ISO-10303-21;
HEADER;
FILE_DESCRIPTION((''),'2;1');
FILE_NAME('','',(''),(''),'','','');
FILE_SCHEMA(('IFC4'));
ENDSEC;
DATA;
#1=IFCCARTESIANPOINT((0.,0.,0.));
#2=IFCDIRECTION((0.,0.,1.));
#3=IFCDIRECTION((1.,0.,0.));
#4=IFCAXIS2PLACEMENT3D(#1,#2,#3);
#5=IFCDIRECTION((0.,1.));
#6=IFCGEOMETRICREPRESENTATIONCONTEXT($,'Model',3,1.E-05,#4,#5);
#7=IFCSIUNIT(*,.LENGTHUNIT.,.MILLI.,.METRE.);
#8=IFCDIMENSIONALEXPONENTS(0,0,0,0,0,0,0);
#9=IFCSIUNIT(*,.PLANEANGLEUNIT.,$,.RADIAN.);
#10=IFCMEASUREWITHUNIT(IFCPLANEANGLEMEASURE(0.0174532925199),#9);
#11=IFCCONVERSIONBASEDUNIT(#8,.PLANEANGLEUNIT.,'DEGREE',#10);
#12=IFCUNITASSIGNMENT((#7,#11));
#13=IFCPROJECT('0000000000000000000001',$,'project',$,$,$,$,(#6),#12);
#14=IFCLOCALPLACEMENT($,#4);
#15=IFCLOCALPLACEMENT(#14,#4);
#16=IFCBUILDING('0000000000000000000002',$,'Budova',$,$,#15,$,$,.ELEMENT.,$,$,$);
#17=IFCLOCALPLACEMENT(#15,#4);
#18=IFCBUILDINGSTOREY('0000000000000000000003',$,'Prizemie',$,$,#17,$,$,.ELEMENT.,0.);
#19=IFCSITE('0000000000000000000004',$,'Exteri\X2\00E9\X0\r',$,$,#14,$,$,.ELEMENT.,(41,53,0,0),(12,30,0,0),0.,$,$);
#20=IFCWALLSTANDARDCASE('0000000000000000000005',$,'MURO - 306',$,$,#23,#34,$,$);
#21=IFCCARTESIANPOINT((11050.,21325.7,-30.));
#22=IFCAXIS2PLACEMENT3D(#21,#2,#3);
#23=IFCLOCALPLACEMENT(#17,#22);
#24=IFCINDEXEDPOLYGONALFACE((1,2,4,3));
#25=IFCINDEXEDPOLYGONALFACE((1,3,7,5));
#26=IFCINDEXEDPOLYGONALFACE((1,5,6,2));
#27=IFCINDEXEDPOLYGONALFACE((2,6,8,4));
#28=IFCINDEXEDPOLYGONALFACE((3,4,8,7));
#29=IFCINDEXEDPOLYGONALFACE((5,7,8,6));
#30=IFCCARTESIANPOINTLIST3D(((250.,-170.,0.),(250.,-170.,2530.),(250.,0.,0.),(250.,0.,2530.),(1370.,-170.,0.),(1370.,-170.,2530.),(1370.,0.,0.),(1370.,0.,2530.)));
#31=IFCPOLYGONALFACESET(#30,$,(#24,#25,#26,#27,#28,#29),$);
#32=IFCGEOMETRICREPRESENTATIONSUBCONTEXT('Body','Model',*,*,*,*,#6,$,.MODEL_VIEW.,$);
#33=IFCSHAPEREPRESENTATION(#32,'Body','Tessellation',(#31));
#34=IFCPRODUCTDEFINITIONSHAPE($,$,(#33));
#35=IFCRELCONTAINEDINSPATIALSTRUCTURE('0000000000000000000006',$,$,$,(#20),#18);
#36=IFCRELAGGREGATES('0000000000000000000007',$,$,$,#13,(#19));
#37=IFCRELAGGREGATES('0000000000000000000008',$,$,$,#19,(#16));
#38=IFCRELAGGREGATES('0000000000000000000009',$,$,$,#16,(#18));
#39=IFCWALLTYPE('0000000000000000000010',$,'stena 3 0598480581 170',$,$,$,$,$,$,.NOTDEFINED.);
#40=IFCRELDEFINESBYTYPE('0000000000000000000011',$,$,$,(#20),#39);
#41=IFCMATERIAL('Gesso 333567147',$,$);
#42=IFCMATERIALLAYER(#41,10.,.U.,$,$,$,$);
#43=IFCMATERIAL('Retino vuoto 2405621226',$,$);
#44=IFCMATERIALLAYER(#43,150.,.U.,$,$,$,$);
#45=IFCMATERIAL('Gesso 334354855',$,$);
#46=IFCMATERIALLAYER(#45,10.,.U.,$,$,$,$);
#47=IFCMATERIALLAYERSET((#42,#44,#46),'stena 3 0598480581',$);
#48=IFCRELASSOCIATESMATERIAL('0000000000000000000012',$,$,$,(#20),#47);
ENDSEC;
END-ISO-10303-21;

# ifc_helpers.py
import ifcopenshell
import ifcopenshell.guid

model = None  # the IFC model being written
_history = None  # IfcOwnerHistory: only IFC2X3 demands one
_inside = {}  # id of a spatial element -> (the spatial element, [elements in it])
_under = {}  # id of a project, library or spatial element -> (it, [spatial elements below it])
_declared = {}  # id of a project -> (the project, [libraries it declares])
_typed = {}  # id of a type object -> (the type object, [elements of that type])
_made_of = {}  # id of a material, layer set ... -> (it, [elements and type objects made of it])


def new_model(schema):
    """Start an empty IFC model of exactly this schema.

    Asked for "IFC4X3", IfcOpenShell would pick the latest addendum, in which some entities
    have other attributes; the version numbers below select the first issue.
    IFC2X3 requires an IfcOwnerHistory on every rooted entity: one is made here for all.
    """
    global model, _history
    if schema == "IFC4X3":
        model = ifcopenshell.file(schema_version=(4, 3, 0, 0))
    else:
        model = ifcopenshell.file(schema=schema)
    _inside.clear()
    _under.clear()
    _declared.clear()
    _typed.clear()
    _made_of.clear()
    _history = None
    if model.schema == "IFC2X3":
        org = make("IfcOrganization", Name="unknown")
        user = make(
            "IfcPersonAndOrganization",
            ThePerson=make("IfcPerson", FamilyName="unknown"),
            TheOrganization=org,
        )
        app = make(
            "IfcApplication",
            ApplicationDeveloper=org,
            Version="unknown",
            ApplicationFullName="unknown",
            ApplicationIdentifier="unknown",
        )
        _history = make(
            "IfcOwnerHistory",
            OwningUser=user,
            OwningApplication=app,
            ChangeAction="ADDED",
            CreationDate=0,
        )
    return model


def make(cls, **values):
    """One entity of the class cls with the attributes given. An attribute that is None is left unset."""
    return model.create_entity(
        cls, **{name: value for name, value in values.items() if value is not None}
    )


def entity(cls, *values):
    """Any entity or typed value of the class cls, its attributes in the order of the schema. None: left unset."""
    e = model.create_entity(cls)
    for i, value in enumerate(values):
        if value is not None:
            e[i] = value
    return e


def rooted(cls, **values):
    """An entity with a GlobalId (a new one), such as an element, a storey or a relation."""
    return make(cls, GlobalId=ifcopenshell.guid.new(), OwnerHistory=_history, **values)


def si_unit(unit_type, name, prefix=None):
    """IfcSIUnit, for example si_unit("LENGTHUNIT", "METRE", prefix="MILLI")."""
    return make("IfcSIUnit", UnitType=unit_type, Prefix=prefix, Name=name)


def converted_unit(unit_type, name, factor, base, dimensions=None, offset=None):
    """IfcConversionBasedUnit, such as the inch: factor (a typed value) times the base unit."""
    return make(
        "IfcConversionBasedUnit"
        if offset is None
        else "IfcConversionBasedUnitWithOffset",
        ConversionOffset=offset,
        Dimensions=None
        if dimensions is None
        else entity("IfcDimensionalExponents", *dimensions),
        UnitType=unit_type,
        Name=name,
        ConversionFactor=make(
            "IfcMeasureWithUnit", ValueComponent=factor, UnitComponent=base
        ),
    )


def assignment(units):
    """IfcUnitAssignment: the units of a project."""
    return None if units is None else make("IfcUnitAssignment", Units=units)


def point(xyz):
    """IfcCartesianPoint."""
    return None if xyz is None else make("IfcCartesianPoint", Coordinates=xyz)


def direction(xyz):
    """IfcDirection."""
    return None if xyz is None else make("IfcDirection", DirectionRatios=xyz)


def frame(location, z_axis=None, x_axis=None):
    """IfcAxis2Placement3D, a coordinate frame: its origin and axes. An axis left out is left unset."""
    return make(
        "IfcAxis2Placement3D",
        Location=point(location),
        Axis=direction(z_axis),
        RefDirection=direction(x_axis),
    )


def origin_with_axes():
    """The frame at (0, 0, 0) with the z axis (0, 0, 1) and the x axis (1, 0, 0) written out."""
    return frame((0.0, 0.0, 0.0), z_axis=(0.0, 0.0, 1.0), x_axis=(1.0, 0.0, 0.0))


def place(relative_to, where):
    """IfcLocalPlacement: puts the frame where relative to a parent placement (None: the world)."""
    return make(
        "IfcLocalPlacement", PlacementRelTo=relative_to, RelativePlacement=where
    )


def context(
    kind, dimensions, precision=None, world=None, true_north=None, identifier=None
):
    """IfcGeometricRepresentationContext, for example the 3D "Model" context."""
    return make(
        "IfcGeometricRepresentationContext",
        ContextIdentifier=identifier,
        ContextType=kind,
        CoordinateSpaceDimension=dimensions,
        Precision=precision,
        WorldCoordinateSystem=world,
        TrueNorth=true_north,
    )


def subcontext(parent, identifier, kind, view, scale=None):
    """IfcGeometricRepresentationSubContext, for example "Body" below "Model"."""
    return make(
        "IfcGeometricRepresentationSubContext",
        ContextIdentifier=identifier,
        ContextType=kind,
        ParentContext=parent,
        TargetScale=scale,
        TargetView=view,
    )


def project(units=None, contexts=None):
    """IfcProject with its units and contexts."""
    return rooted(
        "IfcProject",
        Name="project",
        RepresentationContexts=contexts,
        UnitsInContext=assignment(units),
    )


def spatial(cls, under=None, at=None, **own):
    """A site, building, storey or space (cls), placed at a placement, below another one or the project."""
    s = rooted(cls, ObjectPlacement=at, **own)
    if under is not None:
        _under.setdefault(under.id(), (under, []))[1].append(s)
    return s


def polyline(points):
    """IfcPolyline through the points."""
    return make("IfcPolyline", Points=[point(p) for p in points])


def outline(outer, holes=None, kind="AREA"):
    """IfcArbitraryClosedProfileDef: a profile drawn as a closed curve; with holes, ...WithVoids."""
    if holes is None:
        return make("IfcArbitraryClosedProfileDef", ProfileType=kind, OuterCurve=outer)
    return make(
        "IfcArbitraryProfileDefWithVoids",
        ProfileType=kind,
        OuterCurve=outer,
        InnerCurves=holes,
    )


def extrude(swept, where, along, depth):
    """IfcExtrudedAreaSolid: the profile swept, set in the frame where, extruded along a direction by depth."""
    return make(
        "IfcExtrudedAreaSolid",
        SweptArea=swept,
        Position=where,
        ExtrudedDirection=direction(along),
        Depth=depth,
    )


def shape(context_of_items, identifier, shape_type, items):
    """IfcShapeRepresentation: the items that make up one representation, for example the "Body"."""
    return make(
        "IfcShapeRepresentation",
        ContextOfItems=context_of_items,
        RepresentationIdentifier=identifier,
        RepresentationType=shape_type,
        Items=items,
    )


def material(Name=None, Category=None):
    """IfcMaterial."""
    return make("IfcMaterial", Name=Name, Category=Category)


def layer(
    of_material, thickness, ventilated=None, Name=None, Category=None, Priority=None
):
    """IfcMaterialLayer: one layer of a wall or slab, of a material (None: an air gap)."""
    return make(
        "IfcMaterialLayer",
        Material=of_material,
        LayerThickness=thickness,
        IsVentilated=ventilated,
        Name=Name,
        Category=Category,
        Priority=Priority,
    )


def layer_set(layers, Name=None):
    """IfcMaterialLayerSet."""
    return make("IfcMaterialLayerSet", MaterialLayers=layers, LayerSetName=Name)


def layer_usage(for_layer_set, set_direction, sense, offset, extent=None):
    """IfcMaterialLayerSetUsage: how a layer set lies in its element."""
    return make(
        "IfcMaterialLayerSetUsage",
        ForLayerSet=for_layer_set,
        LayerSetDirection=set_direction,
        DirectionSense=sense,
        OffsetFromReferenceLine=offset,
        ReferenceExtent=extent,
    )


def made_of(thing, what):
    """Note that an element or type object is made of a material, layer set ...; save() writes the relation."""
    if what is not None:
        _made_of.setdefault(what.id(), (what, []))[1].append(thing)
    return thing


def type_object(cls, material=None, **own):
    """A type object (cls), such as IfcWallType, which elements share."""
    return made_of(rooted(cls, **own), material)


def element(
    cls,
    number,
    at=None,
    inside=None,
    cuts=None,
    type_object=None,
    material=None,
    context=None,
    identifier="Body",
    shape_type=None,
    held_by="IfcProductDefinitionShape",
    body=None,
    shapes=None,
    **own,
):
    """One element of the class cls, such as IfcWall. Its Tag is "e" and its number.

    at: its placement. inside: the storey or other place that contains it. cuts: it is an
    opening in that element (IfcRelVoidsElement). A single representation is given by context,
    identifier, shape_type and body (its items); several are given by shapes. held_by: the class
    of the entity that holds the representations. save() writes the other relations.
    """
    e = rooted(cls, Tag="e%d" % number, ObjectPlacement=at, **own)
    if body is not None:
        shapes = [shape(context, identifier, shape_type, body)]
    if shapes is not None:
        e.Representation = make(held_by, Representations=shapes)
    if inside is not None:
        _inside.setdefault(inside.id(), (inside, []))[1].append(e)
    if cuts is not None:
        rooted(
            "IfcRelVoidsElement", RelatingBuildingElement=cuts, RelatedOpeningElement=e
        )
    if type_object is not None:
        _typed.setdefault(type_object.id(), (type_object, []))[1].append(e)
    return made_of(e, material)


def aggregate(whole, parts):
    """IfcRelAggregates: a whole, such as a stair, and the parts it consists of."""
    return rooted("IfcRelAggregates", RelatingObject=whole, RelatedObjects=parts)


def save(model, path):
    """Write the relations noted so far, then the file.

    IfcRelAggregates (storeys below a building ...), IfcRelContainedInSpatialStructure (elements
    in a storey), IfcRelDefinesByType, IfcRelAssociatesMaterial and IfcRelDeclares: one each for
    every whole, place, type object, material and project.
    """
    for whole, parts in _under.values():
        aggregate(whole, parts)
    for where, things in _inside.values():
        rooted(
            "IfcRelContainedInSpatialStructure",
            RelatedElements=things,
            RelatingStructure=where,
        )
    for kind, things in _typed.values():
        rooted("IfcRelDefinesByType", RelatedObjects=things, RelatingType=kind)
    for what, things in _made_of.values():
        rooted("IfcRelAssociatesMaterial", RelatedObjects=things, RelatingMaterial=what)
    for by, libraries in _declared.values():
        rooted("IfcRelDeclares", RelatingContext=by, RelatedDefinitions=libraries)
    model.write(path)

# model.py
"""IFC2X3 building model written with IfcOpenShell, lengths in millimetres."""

from ifc_helpers import new_model, entity, si_unit, converted_unit, direction, frame, origin_with_axes, place, context, subcontext, project, spatial, polyline, outline, extrude, material, layer, layer_set, layer_usage, type_object, element, save


model = new_model("IFC2X3")

# Units and contexts
model_context = context("Model", 3, precision=1e-05, world=origin_with_axes(), true_north=direction((0.0, 1.0)))
body_context = subcontext(model_context, "Body", "Model", "MODEL_VIEW")
ifc_project = project(units=[si_unit("LENGTHUNIT", "METRE", prefix="MILLI"), converted_unit("PLANEANGLEUNIT", "DEGREE", entity("IfcPlaneAngleMeasure", 0.0174532925199), si_unit("PLANEANGLEUNIT", "RADIAN"), dimensions=[0, 0, 0, 0, 0, 0, 0])], contexts=[model_context])

# Site, building, storey
site_placement = place(None, origin_with_axes())
site = spatial("IfcSite", under=ifc_project, at=site_placement, Name="Exteriér", CompositionType="ELEMENT", RefLatitude=(41, 53, 0, 0), RefLongitude=(12, 30, 0, 0), RefElevation=0.0)
building_placement = place(site_placement, origin_with_axes())
building = spatial("IfcBuilding", under=site, at=building_placement, Name="Budova", CompositionType="ELEMENT")
storey_placement = place(building_placement, origin_with_axes())
storey = spatial("IfcBuildingStorey", under=building, at=storey_placement, Name="Prizemie", CompositionType="ELEMENT", Elevation=0.0)

# Wall
ifc_material_1 = material(Name="Gesso 333567147")
ifc_layer_1 = layer(ifc_material_1, 10.0, ventilated="UNKNOWN")
ifc_material_2 = material(Name="Retino vuoto 2405621226")
ifc_layer_2 = layer(ifc_material_2, 150.0, ventilated="UNKNOWN")
ifc_material_3 = material(Name="Gesso 334354855")
ifc_layer_3 = layer(ifc_material_3, 10.0, ventilated="UNKNOWN")
ifc_layer_set_1 = layer_set([ifc_layer_1, ifc_layer_2, ifc_layer_3], Name="stena 3 0598480581")
ifc_layer_usage_1 = layer_usage(ifc_layer_set_1, "AXIS2", "NEGATIVE", 0.0)
wall_type_1 = type_object("IfcWallType", Name="stena 3 0598480581 170", PredefinedType="NOTDEFINED")
wall_1_placement = place(storey_placement, frame((11050.0, 21325.7, -30.0), z_axis=(0.0, 0.0, 1.0), x_axis=(1.0, 0.0, 0.0)))
element("IfcWallStandardCase", 1, at=wall_1_placement, inside=storey, type_object=wall_type_1, material=ifc_layer_usage_1, Name="MURO - 306", context=body_context, shape_type="SweptSolid", body=[
    extrude(outline(polyline([(250.0, -170.0), (1370.0, -170.0), (1370.0, 0.0), (250.0, 0.0), (250.0, -170.0)])), origin_with_axes(), (0.0, 0.0, 1.0), 2530.0),
])

save(model, "model.ifc")
